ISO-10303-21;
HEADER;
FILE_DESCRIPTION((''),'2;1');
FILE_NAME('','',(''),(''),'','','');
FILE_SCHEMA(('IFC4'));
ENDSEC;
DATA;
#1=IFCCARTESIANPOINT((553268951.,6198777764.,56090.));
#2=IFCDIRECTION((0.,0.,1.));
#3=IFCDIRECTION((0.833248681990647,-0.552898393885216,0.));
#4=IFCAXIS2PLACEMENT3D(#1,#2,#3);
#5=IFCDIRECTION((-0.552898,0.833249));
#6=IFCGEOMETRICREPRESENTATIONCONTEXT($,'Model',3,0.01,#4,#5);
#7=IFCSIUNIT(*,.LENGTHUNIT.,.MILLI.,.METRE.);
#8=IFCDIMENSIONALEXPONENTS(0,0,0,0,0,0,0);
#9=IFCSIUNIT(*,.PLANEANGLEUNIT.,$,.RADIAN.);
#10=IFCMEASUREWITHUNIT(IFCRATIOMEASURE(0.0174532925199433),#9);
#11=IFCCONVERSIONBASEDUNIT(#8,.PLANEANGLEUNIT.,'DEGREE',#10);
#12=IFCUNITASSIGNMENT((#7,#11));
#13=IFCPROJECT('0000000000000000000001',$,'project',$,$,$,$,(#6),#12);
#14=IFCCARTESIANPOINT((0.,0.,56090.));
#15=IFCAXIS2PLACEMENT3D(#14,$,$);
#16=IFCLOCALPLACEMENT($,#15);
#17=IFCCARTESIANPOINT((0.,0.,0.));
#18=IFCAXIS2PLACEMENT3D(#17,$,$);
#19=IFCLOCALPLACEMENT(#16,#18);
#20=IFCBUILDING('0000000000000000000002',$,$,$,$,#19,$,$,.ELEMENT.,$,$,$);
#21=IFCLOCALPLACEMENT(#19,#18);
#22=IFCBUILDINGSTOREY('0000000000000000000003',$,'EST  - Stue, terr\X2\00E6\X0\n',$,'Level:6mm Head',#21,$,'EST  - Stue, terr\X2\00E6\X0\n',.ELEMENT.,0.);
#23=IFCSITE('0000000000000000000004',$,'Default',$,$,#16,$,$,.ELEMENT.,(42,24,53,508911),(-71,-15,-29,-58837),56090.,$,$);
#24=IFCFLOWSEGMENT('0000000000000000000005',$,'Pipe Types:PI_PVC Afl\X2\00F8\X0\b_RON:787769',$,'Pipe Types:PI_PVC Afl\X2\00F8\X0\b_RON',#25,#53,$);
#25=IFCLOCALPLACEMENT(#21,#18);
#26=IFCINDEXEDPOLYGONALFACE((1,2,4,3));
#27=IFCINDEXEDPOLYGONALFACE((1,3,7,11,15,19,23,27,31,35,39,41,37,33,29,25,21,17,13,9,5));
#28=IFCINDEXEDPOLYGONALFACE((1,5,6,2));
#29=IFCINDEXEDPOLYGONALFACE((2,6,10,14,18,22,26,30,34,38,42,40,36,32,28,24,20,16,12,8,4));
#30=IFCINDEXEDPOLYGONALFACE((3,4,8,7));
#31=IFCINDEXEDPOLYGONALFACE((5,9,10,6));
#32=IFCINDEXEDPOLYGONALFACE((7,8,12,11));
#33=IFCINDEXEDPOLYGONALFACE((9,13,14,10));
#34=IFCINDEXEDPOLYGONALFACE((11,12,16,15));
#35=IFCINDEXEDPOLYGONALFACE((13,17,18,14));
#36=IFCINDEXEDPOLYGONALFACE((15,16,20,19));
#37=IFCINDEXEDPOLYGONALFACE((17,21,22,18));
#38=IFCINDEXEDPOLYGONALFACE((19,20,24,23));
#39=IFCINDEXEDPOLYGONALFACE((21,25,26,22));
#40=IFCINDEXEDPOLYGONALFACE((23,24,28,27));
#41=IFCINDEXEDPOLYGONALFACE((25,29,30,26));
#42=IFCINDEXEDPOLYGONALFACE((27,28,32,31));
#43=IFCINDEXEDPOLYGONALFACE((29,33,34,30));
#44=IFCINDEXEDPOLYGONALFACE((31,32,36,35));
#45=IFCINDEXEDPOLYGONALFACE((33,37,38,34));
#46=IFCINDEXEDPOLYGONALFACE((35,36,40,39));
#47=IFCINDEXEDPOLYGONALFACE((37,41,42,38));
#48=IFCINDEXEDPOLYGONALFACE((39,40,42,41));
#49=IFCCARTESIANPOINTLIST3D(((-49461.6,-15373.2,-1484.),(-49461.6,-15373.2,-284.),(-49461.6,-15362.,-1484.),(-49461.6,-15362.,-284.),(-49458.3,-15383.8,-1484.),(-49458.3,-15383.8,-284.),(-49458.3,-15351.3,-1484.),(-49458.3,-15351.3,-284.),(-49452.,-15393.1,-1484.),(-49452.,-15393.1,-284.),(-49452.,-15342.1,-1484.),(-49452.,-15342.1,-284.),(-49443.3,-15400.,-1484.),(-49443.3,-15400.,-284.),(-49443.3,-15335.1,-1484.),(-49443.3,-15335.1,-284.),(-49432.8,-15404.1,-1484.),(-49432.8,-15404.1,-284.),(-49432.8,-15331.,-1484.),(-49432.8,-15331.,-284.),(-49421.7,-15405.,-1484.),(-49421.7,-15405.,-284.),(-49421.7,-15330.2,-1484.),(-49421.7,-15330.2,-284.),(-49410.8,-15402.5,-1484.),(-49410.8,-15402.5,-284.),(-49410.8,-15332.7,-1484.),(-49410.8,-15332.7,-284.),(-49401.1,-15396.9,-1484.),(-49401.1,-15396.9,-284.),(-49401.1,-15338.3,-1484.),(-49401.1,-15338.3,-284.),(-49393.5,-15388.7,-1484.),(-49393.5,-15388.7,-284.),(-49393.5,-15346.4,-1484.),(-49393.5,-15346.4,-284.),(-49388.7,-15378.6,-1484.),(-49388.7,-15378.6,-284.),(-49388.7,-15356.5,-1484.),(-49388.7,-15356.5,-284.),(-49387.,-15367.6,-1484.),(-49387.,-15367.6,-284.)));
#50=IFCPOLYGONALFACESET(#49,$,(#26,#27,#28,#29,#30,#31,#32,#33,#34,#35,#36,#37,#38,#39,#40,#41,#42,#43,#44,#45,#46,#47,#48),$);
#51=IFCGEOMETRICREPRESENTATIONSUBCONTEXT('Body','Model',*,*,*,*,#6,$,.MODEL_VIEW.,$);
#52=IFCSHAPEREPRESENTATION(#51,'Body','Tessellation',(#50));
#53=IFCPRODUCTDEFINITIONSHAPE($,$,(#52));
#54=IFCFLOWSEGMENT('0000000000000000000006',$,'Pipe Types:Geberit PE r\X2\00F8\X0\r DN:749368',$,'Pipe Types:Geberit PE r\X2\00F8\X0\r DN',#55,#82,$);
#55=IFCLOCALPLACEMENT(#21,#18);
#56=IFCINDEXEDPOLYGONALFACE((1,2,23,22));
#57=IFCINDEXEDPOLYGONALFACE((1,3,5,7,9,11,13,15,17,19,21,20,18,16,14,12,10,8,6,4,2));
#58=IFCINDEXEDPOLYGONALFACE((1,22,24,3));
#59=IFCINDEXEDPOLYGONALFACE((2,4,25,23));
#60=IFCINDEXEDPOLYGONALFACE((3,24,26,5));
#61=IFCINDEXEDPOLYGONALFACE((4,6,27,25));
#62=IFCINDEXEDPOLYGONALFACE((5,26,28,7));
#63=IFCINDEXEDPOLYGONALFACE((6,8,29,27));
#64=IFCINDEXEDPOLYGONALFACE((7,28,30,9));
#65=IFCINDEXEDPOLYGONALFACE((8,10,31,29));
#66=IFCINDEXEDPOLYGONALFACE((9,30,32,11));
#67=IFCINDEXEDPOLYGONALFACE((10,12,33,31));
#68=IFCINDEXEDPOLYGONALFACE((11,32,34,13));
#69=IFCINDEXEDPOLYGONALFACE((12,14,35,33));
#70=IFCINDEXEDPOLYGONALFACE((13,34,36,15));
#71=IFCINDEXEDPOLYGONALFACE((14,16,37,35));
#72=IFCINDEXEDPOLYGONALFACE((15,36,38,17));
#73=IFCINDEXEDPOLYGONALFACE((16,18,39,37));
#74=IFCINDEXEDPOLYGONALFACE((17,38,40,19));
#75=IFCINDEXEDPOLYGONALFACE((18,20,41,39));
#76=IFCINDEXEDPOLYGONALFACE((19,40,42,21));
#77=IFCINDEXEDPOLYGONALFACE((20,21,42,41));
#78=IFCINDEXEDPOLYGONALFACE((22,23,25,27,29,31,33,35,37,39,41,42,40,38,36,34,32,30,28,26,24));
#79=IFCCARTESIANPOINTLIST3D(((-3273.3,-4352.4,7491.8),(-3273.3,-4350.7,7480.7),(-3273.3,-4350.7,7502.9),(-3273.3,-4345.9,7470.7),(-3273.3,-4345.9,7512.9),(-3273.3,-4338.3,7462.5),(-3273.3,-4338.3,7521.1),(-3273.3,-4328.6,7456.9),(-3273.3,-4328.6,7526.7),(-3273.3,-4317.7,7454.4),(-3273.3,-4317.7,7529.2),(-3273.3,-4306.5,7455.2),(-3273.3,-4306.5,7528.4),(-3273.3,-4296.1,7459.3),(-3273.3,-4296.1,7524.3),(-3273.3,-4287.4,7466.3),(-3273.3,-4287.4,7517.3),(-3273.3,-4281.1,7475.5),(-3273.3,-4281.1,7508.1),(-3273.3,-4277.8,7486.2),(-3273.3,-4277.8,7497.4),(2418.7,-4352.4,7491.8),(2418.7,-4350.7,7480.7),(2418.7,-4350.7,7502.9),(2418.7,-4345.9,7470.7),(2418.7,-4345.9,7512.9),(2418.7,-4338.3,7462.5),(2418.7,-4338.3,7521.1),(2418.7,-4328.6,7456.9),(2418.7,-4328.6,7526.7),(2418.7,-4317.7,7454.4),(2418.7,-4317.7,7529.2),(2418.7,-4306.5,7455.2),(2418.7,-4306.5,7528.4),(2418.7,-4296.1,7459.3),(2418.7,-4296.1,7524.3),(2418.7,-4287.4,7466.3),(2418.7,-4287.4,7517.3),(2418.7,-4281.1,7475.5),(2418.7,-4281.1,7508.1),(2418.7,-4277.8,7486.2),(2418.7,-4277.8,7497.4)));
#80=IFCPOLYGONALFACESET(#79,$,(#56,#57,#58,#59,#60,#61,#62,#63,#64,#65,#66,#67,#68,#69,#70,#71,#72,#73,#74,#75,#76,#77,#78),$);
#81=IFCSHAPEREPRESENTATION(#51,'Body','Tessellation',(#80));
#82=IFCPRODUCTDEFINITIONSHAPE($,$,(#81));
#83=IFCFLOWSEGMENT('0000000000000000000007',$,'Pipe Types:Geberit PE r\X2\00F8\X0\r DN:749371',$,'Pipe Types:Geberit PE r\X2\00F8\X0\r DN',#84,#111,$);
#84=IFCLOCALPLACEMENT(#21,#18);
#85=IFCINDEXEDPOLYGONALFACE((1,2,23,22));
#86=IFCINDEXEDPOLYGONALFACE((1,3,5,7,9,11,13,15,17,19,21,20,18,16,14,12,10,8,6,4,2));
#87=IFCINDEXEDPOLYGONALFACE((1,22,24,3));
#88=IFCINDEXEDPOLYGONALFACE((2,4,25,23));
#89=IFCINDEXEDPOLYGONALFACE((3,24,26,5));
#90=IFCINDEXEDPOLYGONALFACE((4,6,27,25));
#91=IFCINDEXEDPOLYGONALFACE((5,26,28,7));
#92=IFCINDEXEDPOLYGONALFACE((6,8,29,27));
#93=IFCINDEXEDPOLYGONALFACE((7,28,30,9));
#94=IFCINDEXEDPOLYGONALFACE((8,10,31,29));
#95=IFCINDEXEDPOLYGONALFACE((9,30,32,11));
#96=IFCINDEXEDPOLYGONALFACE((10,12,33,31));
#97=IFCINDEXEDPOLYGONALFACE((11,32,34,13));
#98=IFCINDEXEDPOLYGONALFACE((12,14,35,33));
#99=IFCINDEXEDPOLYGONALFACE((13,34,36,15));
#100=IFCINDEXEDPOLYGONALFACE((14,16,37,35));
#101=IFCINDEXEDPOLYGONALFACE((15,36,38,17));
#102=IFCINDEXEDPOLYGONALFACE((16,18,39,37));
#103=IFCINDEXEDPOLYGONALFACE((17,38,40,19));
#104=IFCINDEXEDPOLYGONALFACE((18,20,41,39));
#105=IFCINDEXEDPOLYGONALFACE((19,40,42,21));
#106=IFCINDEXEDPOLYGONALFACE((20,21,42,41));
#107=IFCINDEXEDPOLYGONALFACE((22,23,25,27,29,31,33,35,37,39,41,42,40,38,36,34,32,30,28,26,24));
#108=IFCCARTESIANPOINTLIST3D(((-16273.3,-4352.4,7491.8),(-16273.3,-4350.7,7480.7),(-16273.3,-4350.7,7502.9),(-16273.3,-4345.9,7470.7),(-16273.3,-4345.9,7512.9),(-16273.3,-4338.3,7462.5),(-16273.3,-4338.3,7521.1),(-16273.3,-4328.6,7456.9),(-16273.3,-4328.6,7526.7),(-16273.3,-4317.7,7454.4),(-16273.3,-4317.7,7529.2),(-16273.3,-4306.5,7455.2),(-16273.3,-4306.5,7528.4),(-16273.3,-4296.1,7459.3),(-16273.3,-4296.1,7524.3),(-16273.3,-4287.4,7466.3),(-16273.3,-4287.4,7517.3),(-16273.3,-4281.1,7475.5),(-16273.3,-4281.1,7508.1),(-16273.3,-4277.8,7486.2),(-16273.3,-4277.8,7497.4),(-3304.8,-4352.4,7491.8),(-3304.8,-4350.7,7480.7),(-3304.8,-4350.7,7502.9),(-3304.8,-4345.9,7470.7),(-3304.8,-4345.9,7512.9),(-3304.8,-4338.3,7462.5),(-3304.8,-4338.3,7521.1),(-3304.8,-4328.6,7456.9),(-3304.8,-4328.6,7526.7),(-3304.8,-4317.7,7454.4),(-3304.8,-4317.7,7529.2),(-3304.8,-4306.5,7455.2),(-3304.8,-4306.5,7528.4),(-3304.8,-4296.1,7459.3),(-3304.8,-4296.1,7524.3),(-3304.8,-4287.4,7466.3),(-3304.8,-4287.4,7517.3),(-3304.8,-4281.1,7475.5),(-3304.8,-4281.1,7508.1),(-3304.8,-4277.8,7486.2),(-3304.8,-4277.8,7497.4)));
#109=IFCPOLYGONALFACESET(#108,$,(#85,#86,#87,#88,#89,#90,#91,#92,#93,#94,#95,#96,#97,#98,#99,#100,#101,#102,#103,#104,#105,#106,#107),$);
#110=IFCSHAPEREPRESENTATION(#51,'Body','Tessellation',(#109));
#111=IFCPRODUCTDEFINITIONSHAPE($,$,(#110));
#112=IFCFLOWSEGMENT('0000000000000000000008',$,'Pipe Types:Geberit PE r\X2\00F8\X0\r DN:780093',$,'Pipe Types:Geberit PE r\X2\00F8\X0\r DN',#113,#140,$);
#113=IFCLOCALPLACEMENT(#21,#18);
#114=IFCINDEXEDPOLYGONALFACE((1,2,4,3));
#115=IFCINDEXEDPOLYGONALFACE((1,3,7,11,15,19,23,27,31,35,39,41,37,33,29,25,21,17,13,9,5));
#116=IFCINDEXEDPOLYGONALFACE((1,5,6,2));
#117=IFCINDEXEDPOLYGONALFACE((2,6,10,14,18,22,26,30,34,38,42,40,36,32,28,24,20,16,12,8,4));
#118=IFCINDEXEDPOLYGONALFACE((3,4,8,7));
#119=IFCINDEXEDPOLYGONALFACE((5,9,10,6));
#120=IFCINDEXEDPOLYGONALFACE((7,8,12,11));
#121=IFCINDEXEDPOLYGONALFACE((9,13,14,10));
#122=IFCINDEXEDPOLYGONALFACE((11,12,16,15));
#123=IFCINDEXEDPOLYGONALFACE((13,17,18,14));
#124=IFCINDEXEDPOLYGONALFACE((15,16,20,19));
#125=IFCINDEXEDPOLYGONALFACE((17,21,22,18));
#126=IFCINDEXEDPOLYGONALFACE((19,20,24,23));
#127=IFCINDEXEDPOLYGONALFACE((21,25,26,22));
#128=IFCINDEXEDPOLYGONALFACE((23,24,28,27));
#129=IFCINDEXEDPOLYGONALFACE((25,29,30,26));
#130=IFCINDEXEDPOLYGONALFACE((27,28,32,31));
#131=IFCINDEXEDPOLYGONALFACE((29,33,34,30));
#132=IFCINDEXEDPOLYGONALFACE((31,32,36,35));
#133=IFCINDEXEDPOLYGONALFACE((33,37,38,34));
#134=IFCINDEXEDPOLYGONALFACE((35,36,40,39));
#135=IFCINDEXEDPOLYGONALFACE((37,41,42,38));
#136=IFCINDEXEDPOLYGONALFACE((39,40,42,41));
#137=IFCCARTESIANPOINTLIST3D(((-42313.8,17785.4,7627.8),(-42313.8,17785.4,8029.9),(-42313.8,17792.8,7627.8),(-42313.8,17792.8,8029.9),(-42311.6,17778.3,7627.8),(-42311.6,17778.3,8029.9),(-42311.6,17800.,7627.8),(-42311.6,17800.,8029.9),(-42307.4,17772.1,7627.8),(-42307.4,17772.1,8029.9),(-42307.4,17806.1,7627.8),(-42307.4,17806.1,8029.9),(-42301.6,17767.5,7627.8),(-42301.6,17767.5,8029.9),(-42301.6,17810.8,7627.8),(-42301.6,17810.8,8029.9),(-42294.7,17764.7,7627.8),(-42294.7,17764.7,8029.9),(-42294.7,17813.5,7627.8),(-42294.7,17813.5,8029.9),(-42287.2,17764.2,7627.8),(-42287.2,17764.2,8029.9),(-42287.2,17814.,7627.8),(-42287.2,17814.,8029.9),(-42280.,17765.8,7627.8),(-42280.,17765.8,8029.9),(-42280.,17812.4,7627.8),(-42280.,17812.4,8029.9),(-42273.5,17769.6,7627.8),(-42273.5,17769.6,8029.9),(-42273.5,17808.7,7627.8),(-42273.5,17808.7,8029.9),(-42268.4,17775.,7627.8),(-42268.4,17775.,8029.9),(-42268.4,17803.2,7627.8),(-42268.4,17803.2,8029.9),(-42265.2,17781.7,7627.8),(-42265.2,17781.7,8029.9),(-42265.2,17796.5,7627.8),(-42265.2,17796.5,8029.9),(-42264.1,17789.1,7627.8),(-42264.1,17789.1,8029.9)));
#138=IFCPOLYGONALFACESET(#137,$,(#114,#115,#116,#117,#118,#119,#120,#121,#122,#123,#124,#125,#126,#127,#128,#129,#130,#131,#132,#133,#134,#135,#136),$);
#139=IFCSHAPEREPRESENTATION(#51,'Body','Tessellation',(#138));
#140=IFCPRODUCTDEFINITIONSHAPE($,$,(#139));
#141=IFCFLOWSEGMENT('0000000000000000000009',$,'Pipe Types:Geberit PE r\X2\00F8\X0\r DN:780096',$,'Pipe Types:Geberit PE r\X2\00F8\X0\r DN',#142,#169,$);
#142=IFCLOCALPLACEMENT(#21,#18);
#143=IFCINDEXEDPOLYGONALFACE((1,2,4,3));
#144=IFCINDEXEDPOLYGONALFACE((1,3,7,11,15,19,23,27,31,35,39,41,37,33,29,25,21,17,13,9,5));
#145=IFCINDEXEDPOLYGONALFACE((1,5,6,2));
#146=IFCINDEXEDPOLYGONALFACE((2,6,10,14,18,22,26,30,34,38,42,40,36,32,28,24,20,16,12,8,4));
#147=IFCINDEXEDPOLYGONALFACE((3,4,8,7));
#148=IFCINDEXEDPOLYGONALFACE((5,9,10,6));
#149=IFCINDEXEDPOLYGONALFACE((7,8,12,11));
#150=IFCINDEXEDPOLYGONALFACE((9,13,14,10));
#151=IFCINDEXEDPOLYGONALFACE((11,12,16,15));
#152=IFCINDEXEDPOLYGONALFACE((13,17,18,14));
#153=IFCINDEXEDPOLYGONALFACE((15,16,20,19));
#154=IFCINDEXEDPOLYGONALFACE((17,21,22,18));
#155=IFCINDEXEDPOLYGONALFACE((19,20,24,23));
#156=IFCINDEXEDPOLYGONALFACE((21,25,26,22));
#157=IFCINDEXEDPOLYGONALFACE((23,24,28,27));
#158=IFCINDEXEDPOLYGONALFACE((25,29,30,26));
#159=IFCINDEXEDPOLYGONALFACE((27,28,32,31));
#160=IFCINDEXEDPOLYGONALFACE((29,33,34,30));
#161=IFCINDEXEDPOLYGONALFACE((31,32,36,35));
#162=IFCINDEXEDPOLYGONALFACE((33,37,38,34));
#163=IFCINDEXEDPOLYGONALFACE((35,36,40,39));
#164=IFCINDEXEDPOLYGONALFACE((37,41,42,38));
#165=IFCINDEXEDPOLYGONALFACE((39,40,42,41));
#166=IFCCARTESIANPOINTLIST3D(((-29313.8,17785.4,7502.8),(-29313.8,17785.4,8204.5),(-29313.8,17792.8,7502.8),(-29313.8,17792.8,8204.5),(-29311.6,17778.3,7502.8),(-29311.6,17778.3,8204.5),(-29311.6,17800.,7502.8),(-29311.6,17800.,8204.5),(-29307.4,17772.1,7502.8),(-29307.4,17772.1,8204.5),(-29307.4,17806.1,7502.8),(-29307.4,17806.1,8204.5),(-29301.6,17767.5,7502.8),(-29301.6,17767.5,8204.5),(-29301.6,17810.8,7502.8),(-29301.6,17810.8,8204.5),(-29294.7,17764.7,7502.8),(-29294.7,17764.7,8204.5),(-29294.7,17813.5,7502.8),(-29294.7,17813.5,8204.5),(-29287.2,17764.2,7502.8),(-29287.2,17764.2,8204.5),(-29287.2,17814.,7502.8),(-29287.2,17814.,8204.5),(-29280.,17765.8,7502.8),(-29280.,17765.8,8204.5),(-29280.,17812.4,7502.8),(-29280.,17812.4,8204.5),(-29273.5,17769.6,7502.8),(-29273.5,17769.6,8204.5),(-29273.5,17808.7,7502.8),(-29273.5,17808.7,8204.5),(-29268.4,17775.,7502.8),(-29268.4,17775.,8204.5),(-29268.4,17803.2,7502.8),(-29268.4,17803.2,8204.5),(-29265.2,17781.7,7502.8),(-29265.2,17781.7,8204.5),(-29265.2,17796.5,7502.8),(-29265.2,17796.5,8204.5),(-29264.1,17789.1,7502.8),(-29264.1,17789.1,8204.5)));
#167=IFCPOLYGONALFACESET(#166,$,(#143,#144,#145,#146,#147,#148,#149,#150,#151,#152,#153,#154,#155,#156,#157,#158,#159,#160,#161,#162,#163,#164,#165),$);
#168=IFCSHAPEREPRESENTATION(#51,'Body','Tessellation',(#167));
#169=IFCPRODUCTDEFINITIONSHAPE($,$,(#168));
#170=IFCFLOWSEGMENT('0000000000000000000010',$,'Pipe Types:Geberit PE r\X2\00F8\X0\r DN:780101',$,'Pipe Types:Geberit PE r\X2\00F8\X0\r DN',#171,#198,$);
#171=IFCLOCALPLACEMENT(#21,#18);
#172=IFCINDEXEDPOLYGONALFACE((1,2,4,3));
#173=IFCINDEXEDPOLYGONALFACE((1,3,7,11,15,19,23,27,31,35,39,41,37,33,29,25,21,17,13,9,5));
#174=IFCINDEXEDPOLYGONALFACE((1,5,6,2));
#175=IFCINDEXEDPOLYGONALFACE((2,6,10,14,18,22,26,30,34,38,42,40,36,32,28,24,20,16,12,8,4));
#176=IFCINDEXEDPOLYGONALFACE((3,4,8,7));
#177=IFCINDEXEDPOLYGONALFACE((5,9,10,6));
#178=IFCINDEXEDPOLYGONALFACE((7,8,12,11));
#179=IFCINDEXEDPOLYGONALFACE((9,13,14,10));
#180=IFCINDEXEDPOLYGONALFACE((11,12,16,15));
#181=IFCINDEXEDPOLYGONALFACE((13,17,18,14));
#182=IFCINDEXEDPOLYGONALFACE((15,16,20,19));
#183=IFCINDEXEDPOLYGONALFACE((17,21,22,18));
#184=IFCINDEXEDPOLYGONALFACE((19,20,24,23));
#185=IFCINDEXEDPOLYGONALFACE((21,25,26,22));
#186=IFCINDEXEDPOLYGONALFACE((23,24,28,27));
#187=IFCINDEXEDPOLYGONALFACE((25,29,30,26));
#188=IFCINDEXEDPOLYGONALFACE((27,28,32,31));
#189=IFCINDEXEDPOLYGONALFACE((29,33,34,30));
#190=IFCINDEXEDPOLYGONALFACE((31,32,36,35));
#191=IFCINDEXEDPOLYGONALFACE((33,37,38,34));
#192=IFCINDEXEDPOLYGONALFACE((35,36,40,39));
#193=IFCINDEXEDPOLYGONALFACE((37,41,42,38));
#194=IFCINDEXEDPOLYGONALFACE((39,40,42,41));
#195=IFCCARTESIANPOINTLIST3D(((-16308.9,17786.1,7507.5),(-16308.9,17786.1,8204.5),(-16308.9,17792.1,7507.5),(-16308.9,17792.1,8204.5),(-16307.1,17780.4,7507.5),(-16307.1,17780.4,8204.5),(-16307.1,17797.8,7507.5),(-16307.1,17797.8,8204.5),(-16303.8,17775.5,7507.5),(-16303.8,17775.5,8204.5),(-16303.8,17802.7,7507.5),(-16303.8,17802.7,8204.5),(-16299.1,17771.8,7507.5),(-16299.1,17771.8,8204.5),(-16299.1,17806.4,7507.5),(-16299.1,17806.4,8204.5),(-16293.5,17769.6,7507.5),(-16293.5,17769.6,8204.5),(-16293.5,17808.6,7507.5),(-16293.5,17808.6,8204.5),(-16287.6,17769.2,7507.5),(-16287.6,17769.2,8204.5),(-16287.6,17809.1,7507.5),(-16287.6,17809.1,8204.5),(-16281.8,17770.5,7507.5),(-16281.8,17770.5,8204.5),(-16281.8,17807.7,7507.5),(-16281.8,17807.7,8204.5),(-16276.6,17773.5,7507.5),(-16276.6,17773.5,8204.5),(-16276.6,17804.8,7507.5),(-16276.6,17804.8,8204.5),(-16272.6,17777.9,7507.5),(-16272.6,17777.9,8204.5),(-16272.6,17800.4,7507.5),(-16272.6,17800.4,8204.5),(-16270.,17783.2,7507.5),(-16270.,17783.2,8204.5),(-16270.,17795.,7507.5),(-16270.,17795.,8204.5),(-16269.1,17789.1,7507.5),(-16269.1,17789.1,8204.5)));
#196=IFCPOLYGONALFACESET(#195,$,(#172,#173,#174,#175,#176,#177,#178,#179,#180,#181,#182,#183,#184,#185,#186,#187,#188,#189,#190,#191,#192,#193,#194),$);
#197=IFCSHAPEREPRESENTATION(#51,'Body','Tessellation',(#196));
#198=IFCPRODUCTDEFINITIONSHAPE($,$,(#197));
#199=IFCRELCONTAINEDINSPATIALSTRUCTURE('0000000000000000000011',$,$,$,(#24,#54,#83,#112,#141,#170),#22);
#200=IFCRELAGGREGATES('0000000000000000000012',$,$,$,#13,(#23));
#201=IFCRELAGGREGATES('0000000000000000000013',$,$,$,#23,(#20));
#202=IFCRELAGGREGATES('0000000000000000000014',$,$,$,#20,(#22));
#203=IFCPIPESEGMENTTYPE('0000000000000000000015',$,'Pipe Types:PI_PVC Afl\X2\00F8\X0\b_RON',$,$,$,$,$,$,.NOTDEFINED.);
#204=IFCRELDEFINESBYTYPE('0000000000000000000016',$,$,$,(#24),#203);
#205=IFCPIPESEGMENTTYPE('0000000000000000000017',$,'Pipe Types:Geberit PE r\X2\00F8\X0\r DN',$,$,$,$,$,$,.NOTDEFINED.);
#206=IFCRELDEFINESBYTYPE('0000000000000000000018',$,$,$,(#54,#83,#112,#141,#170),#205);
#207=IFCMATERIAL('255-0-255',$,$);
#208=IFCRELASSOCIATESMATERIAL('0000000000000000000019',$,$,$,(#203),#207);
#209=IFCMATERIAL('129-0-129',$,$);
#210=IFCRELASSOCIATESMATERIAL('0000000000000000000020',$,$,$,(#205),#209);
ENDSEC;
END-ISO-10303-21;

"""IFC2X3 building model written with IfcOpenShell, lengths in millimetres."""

from ifc_helpers import new_model, entity, si_unit, converted_unit, direction, frame, frame_2d, origin, origin_2d_with_axis, place, context, subcontext, project, spatial, circle, extrude, material, type_object, element, save


model = new_model("IFC2X3")

# Units and contexts
model_context = context("Model", 3, precision=0.01, world=frame((553268951.0, 6198777764.0, 56090.0), z_axis=(0.0, 0.0, 1.0), x_axis=(0.833248681990647, -0.552898393885216, 0.0)), true_north=direction((-0.552898, 0.833249)))
body_context = subcontext(model_context, "Body", "Model", "MODEL_VIEW")
ifc_project = project(units=[si_unit("LENGTHUNIT", "METRE", prefix="MILLI"), converted_unit("PLANEANGLEUNIT", "DEGREE", entity("IfcRatioMeasure", 0.0174532925199433), si_unit("PLANEANGLEUNIT", "RADIAN"), dimensions=[0, 0, 0, 0, 0, 0, 0])], contexts=[model_context])

# Site, building, storey
site_placement = place(None, frame((0.0, 0.0, 56090.0)))
site = spatial("IfcSite", under=ifc_project, at=site_placement, Name="Default", CompositionType="ELEMENT", RefLatitude=(42, 24, 53, 508911), RefLongitude=(-71, -15, -29, -58837), RefElevation=56090.0)
building_placement = place(site_placement, origin())
building = spatial("IfcBuilding", under=site, at=building_placement, CompositionType="ELEMENT")
storey_placement = place(building_placement, frame((0.0, 0.0, 0.0)))
storey = spatial("IfcBuildingStorey", under=building, at=storey_placement, Name="EST  - Stue, terræn", ObjectType="Level:6mm Head", LongName="EST  - Stue, terræn", CompositionType="ELEMENT", Elevation=0.0)

# Flow segments
ifc_material_1 = material(Name="129-0-129")
ifc_material_2 = material(Name="255-0-255")
pipe_segment_type_1 = type_object("IfcPipeSegmentType", Name="Pipe Types:PI_PVC Afløb_RON", PredefinedType="NOTDEFINED", material=ifc_material_2)
flow_segment_1_placement = place(storey_placement, origin())
element("IfcFlowSegment", 1, at=flow_segment_1_placement, inside=storey, type_object=pipe_segment_type_1, Name="Pipe Types:PI_PVC Afløb_RON:787769", ObjectType="Pipe Types:PI_PVC Afløb_RON", context=body_context, shape_type="SweptSolid", body=[
    extrude(circle(Radius=37.5, at=frame_2d((0.0, 0.0), x_axis=(1.0, 0.0))), frame((-49424.5, -15367.6, -1484.0)), (0.0, 0.0, 1.0), 1200.0),
])
pipe_segment_type_2 = type_object("IfcPipeSegmentType", Name="Pipe Types:Geberit PE rør DN", PredefinedType="NOTDEFINED", material=ifc_material_1)
flow_segment_2_placement = place(storey_placement, origin())
element("IfcFlowSegment", 2, at=flow_segment_2_placement, inside=storey, type_object=pipe_segment_type_2, Name="Pipe Types:Geberit PE rør DN:749368", ObjectType="Pipe Types:Geberit PE rør DN", context=body_context, shape_type="SweptSolid", body=[
    extrude(circle(Radius=37.5, at=origin_2d_with_axis()), frame((-3273.3, -4314.9, 7491.8), z_axis=(1.0, 0.0, 0.0), x_axis=(0.0, -1.0, 0.0)), (0.0, 0.0, 1.0), 5692.0),
])
flow_segment_3_placement = place(storey_placement, origin())
element("IfcFlowSegment", 3, at=flow_segment_3_placement, inside=storey, type_object=pipe_segment_type_2, Name="Pipe Types:Geberit PE rør DN:749371", ObjectType="Pipe Types:Geberit PE rør DN", context=body_context, shape_type="SweptSolid", body=[
    extrude(circle(Radius=37.5, at=origin_2d_with_axis()), frame((-16273.3, -4314.9, 7491.8), z_axis=(1.0, 0.0, 0.0), x_axis=(0.0, -1.0, 0.0)), (0.0, 0.0, 1.0), 12968.5),
])
flow_segment_4_placement = place(storey_placement, origin())
element("IfcFlowSegment", 4, at=flow_segment_4_placement, inside=storey, type_object=pipe_segment_type_2, Name="Pipe Types:Geberit PE rør DN:780093", ObjectType="Pipe Types:Geberit PE rør DN", context=body_context, shape_type="SweptSolid", body=[
    extrude(circle(Radius=25.0, at=frame_2d((0.0, 0.0), x_axis=(1.0, 0.0))), frame((-42289.1, 17789.1, 7627.8)), (0.0, 0.0, 1.0), 402.1),
])
flow_segment_5_placement = place(storey_placement, origin())
element("IfcFlowSegment", 5, at=flow_segment_5_placement, inside=storey, type_object=pipe_segment_type_2, Name="Pipe Types:Geberit PE rør DN:780096", ObjectType="Pipe Types:Geberit PE rør DN", context=body_context, shape_type="SweptSolid", body=[
    extrude(circle(Radius=25.0, at=origin_2d_with_axis()), frame((-29289.1, 17789.1, 7502.8)), (0.0, 0.0, 1.0), 701.7),
])
flow_segment_6_placement = place(storey_placement, origin())
element("IfcFlowSegment", 6, at=flow_segment_6_placement, inside=storey, type_object=pipe_segment_type_2, Name="Pipe Types:Geberit PE rør DN:780101", ObjectType="Pipe Types:Geberit PE rør DN", context=body_context, shape_type="SweptSolid", body=[
    extrude(circle(Radius=20.0, at=origin_2d_with_axis()), frame((-16289.1, 17789.1, 7507.5)), (0.0, 0.0, 1.0), 696.9),
])

save(model, "model.ifc")
